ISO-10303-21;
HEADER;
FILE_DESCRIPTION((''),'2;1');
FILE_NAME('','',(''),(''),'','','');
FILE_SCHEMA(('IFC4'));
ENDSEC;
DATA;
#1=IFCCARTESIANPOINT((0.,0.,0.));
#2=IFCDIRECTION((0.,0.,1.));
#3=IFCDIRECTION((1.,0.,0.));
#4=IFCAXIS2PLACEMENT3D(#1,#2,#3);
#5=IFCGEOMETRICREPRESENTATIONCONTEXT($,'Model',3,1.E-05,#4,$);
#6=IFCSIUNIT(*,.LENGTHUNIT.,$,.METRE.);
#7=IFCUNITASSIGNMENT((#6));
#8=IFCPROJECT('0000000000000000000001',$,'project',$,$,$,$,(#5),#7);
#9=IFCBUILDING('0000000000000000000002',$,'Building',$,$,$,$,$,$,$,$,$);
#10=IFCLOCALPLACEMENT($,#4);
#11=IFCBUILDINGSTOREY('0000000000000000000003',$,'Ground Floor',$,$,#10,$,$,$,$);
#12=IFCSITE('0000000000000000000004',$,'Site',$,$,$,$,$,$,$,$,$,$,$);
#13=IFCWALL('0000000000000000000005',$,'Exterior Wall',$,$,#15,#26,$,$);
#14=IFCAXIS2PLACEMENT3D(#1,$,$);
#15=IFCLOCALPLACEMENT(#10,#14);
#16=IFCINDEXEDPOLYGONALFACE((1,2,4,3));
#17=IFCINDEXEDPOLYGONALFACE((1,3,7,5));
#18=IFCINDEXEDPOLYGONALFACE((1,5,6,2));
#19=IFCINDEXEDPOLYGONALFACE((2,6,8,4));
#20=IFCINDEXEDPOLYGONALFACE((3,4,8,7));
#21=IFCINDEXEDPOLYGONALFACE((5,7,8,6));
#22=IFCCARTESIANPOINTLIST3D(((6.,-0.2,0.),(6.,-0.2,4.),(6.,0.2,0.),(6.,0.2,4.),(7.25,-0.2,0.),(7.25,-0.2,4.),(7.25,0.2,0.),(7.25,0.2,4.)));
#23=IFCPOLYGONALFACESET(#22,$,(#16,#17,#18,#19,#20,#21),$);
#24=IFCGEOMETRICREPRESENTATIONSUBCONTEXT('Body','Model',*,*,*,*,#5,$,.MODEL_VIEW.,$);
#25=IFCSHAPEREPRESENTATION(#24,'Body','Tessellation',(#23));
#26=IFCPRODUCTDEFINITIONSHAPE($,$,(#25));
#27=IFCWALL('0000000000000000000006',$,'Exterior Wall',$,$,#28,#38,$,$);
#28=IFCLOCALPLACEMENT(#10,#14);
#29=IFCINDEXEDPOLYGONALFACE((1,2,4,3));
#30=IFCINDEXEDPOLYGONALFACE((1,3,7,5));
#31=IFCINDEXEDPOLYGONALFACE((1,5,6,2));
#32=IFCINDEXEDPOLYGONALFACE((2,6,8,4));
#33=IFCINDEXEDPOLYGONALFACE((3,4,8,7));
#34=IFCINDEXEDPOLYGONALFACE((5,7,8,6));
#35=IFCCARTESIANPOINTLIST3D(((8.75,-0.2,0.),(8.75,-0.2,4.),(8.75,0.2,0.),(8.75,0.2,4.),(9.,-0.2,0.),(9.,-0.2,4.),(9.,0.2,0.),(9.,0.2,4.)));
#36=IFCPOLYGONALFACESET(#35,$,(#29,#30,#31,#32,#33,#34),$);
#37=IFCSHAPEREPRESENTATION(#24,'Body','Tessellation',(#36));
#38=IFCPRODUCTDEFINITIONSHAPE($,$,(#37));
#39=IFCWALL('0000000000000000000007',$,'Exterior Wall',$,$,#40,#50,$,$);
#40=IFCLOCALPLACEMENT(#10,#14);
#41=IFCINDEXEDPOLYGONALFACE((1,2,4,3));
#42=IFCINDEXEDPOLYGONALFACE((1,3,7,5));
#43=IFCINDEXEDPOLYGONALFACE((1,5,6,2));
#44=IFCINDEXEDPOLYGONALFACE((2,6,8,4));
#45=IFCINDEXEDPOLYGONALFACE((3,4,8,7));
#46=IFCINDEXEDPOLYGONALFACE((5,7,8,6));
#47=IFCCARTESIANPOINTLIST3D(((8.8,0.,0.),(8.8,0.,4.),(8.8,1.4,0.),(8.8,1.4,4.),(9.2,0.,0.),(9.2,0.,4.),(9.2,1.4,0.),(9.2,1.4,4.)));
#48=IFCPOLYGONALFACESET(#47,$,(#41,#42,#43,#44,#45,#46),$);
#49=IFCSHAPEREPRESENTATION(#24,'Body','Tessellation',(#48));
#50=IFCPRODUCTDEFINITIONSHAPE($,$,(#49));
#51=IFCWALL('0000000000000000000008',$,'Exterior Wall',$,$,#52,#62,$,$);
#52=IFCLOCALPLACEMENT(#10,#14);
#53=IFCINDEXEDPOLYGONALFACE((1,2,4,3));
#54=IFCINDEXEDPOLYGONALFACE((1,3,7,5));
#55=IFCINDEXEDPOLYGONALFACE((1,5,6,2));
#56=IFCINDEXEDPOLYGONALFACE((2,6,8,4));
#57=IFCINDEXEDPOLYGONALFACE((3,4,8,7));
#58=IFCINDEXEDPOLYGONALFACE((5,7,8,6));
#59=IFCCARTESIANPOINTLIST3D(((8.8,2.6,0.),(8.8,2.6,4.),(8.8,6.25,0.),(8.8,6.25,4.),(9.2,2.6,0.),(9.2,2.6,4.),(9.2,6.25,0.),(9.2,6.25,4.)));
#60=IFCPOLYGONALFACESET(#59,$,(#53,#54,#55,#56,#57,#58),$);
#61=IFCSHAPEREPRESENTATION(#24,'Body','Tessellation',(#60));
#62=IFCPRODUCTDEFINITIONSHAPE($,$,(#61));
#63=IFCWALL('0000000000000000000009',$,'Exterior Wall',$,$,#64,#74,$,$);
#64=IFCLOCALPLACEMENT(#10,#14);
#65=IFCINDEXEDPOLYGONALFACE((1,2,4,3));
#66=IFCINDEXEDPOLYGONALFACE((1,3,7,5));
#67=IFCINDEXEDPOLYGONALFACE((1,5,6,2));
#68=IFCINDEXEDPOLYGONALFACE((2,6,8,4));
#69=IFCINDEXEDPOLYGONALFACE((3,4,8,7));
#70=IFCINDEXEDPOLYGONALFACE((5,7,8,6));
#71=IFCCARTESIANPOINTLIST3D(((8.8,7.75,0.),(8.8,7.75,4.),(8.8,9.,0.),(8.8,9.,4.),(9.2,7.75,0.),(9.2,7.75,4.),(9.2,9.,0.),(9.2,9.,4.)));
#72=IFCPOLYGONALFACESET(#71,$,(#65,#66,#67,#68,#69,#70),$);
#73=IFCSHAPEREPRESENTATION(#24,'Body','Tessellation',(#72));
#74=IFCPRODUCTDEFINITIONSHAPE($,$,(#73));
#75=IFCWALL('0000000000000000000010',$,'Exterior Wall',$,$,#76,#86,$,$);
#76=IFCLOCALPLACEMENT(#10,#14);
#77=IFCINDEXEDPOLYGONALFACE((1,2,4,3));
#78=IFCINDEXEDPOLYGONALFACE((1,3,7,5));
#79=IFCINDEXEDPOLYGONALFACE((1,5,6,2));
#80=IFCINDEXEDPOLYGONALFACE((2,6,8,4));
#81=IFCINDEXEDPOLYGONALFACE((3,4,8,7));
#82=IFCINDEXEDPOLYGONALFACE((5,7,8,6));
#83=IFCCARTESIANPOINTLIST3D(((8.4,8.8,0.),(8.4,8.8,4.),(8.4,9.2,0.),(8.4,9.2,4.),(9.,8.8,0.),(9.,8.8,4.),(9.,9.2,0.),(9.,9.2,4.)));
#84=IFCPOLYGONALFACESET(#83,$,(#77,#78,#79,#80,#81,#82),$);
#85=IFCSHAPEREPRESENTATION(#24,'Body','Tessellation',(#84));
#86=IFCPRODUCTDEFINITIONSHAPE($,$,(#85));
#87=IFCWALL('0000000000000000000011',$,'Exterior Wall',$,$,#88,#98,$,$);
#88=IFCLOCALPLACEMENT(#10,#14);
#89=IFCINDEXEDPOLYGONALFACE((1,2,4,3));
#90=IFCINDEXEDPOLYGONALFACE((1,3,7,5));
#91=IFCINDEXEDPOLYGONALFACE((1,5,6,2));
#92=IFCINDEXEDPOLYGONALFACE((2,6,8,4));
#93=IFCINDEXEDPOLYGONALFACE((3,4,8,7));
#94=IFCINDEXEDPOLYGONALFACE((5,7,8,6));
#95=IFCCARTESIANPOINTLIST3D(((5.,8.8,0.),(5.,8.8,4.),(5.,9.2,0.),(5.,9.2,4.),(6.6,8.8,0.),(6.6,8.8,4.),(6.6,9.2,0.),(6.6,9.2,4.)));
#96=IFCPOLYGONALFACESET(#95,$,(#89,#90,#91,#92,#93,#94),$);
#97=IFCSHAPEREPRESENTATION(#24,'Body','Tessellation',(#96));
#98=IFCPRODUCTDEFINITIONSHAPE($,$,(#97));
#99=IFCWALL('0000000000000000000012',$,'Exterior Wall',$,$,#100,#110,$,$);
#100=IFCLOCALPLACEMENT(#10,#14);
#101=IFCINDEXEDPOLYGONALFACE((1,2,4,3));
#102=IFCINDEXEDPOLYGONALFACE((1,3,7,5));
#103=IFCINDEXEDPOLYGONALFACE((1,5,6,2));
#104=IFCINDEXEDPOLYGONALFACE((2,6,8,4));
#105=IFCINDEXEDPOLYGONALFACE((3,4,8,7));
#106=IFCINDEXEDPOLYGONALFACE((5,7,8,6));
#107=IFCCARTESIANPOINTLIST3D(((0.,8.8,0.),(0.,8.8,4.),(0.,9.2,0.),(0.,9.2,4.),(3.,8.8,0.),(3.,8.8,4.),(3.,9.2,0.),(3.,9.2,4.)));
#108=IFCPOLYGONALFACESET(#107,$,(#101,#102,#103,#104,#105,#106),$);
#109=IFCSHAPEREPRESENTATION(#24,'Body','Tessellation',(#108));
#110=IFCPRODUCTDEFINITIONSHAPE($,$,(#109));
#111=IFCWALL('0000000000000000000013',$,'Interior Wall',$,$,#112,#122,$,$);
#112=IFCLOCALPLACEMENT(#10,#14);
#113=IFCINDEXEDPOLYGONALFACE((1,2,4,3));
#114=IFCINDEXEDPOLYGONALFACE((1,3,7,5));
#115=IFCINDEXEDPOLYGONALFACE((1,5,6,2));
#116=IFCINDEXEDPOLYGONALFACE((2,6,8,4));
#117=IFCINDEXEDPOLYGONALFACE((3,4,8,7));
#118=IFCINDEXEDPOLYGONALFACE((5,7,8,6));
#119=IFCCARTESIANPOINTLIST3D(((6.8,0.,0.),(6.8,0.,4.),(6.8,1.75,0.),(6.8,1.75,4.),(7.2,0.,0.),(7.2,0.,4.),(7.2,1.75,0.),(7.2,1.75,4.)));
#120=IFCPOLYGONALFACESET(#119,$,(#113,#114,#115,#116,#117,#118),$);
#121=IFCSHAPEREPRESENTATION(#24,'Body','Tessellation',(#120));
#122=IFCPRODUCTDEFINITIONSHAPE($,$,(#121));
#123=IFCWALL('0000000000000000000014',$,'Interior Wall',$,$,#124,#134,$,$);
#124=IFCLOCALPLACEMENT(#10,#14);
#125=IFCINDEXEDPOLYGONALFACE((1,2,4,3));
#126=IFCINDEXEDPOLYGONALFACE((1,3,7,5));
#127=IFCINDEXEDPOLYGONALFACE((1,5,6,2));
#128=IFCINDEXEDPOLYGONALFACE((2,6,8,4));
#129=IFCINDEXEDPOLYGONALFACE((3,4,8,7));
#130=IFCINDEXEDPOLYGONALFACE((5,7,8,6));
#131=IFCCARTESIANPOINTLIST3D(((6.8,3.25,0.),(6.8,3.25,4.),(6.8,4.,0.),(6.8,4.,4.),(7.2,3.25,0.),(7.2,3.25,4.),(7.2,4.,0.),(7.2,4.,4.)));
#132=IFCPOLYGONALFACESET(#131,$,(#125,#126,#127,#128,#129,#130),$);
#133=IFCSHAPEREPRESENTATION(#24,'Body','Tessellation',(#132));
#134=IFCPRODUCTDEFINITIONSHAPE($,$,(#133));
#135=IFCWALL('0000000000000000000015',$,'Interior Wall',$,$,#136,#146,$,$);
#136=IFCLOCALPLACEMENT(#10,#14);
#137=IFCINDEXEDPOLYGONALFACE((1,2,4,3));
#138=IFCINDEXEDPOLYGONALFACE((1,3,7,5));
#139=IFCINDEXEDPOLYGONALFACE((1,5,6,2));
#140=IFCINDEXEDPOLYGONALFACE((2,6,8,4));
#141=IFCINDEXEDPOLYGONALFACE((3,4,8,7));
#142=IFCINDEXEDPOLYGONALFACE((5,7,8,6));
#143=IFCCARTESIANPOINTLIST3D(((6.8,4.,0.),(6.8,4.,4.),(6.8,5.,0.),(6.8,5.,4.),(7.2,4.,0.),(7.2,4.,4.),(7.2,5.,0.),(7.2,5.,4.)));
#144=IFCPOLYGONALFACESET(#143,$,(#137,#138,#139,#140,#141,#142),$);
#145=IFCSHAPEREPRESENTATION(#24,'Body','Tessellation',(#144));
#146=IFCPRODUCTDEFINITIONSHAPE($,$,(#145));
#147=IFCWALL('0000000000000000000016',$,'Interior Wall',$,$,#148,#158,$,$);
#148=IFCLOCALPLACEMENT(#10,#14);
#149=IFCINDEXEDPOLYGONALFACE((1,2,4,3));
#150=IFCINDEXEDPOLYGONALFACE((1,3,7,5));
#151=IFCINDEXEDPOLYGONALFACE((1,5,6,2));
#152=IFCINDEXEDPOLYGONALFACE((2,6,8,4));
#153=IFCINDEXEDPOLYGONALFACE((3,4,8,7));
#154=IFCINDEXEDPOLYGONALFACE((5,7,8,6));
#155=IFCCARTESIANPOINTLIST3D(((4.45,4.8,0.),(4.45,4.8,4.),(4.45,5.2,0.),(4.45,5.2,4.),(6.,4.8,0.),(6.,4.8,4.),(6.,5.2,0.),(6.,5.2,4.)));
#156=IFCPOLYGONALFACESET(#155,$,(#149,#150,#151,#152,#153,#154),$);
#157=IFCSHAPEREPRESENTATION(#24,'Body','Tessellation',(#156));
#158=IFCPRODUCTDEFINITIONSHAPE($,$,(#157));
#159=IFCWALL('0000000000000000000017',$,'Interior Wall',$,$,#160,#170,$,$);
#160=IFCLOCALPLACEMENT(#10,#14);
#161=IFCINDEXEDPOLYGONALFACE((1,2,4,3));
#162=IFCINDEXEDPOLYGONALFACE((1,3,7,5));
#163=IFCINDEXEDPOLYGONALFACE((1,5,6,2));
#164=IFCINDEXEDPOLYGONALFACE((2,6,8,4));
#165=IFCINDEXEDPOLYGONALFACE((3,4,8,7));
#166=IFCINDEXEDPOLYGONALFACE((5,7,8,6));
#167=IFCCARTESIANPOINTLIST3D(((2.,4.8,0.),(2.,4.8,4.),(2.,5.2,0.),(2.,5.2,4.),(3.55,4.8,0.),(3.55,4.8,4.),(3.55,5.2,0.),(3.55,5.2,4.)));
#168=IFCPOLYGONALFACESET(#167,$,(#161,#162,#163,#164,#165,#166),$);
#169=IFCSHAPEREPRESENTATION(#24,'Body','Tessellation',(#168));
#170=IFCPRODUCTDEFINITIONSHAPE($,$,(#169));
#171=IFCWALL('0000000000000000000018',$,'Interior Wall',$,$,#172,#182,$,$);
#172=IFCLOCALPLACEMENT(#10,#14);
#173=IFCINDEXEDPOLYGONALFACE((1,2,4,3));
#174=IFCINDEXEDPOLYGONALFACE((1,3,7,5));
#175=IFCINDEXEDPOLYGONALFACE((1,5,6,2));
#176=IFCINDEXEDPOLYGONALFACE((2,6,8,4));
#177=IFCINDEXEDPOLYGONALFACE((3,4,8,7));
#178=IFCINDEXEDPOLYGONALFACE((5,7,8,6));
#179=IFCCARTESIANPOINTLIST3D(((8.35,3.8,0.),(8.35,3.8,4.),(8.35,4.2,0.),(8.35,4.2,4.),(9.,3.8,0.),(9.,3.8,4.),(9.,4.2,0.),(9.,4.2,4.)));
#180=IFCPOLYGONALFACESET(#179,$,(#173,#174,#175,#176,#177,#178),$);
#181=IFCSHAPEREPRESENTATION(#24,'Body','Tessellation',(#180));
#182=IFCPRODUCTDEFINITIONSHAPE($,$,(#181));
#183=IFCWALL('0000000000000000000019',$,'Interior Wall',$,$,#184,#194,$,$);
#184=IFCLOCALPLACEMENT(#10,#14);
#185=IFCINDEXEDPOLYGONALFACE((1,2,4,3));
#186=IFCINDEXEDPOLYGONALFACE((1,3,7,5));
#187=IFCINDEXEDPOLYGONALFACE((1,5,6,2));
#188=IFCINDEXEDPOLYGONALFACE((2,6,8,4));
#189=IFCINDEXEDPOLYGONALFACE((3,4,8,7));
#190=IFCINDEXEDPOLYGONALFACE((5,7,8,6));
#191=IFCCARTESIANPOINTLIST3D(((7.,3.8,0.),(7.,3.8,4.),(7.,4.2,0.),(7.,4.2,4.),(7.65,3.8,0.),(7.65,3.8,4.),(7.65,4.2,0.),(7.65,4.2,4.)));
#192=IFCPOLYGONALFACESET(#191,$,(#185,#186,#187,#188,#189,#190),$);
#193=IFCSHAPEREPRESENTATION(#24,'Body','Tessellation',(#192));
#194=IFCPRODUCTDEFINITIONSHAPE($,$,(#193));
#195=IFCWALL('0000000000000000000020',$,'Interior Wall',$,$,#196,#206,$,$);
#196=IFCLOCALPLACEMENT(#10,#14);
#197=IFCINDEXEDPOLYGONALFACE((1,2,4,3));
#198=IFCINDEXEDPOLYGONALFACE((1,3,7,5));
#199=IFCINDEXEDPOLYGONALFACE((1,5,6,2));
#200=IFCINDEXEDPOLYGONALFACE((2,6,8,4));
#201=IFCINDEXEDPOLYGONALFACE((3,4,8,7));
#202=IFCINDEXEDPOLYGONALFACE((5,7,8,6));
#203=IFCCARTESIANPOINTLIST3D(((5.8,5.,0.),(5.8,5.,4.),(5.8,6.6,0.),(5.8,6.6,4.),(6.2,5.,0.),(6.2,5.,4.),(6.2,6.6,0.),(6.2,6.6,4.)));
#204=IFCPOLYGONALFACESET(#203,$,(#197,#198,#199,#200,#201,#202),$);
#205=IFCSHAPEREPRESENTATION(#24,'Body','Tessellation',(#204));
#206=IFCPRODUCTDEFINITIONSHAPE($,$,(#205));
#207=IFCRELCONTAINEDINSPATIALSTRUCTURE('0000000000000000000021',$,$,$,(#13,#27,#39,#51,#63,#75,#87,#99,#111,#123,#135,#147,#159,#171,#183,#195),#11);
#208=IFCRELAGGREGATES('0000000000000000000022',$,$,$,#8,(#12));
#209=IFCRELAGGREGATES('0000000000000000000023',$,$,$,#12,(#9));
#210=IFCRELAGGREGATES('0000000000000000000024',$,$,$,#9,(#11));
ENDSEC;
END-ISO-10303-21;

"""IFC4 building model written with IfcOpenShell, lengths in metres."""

from ifc_helpers import new_model, si_unit, frame, origin_with_axes, place, context, subcontext, project, spatial, indexed_curve, outline, extrude, element, save


model = new_model("IFC4")

# Units and contexts
model_context = context("Model", 3, precision=1e-05, world=origin_with_axes())
body_context = subcontext(model_context, "Body", "Model", "MODEL_VIEW")
ifc_project = project(units=[si_unit("LENGTHUNIT", "METRE")], contexts=[model_context])

# Site, building, storey
site = spatial("IfcSite", under=ifc_project, Name="Site")
building = spatial("IfcBuilding", under=site, Name="Building")
storey_placement = place(None, origin_with_axes())
storey = spatial("IfcBuildingStorey", under=building, at=storey_placement, Name="Ground Floor")

# Walls
wall_1_placement = place(storey_placement, frame((6.0, 0.0, 0.0), z_axis=(0.0, 0.0, 1.0), x_axis=(1.0, 0.0, 0.0)))
element("IfcWall", 1, at=wall_1_placement, inside=storey, Name="Exterior Wall", context=body_context, shape_type="SweptSolid", body=[
    extrude(outline(indexed_curve([(0.0, 0.0), (0.0, 0.4), (1.25, 0.4), (1.25, 0.0), (0.0, 0.0)], self_intersect=False)), frame((0.0, -0.2, 0.0), z_axis=(0.0, 0.0, 1.0), x_axis=(1.0, 0.0, 0.0)), (0.0, 0.0, 1.0), 4.0),
])
wall_2_placement = place(storey_placement, frame((8.75, 0.0, 0.0), z_axis=(0.0, 0.0, 1.0), x_axis=(1.0, 0.0, 0.0)))
element("IfcWall", 2, at=wall_2_placement, inside=storey, Name="Exterior Wall", context=body_context, shape_type="SweptSolid", body=[
    extrude(outline(indexed_curve([(0.0, 0.0), (0.0, 0.4), (0.25, 0.4), (0.25, 0.0), (0.0, 0.0)], self_intersect=False)), frame((0.0, -0.2, 0.0), z_axis=(0.0, 0.0, 1.0), x_axis=(1.0, 0.0, 0.0)), (0.0, 0.0, 1.0), 4.0),
])
wall_3_placement = place(storey_placement, frame((9.0, 0.0, 0.0), z_axis=(0.0, 0.0, 1.0), x_axis=(0.0, 1.0, 0.0)))
element("IfcWall", 3, at=wall_3_placement, inside=storey, Name="Exterior Wall", context=body_context, shape_type="SweptSolid", body=[
    extrude(outline(indexed_curve([(0.0, 0.0), (0.0, 0.4), (1.4, 0.4), (1.4, 0.0), (0.0, 0.0)], self_intersect=False)), frame((0.0, -0.2, 0.0), z_axis=(0.0, 0.0, 1.0), x_axis=(1.0, 0.0, 0.0)), (0.0, 0.0, 1.0), 4.0),
])
wall_4_placement = place(storey_placement, frame((9.0, 2.6, 0.0), z_axis=(0.0, 0.0, 1.0), x_axis=(0.0, 1.0, 0.0)))
element("IfcWall", 4, at=wall_4_placement, inside=storey, Name="Exterior Wall", context=body_context, shape_type="SweptSolid", body=[
    extrude(outline(indexed_curve([(0.0, 0.0), (0.0, 0.4), (3.65, 0.4), (3.65, 0.0), (0.0, 0.0)], self_intersect=False)), frame((0.0, -0.2, 0.0), z_axis=(0.0, 0.0, 1.0), x_axis=(1.0, 0.0, 0.0)), (0.0, 0.0, 1.0), 4.0),
])
wall_5_placement = place(storey_placement, frame((9.0, 7.75, 0.0), z_axis=(0.0, 0.0, 1.0), x_axis=(0.0, 1.0, 0.0)))
element("IfcWall", 5, at=wall_5_placement, inside=storey, Name="Exterior Wall", context=body_context, shape_type="SweptSolid", body=[
    extrude(outline(indexed_curve([(0.0, 0.0), (0.0, 0.4), (1.25, 0.4), (1.25, 0.0), (0.0, 0.0)], self_intersect=False)), frame((0.0, -0.2, 0.0), z_axis=(0.0, 0.0, 1.0), x_axis=(1.0, 0.0, 0.0)), (0.0, 0.0, 1.0), 4.0),
])
wall_6_placement = place(storey_placement, frame((9.0, 9.0, 0.0), z_axis=(0.0, 0.0, 1.0), x_axis=(-1.0, 0.0, 0.0)))
element("IfcWall", 6, at=wall_6_placement, inside=storey, Name="Exterior Wall", context=body_context, shape_type="SweptSolid", body=[
    extrude(outline(indexed_curve([(0.0, 0.0), (0.0, 0.4), (0.6, 0.4), (0.6, 0.0), (0.0, 0.0)], self_intersect=False)), frame((0.0, -0.2, 0.0), z_axis=(0.0, 0.0, 1.0), x_axis=(1.0, 0.0, 0.0)), (0.0, 0.0, 1.0), 4.0),
])
wall_7_placement = place(storey_placement, frame((6.6, 9.0, 0.0), z_axis=(0.0, 0.0, 1.0), x_axis=(-1.0, 0.0, 0.0)))
element("IfcWall", 7, at=wall_7_placement, inside=storey, Name="Exterior Wall", context=body_context, shape_type="SweptSolid", body=[
    extrude(outline(indexed_curve([(0.0, 0.0), (0.0, 0.4), (1.6, 0.4), (1.6, 0.0), (0.0, 0.0)], self_intersect=False)), frame((0.0, -0.2, 0.0), z_axis=(0.0, 0.0, 1.0), x_axis=(1.0, 0.0, 0.0)), (0.0, 0.0, 1.0), 4.0),
])
wall_8_placement = place(storey_placement, frame((3.0, 9.0, 0.0), z_axis=(0.0, 0.0, 1.0), x_axis=(-1.0, 0.0, 0.0)))
element("IfcWall", 8, at=wall_8_placement, inside=storey, Name="Exterior Wall", context=body_context, shape_type="SweptSolid", body=[
    extrude(outline(indexed_curve([(0.0, 0.0), (0.0, 0.4), (3.0, 0.4), (3.0, 0.0), (0.0, 0.0)], self_intersect=False)), frame((0.0, -0.2, 0.0), z_axis=(0.0, 0.0, 1.0), x_axis=(1.0, 0.0, 0.0)), (0.0, 0.0, 1.0), 4.0),
])
wall_9_placement = place(storey_placement, frame((7.0, 0.0, 0.0), z_axis=(0.0, 0.0, 1.0), x_axis=(0.0, 1.0, 0.0)))
element("IfcWall", 9, at=wall_9_placement, inside=storey, Name="Interior Wall", context=body_context, shape_type="SweptSolid", body=[
    extrude(outline(indexed_curve([(0.0, 0.0), (0.0, 0.4), (1.75, 0.4), (1.75, 0.0), (0.0, 0.0)], self_intersect=False)), frame((0.0, -0.2, 0.0), z_axis=(0.0, 0.0, 1.0), x_axis=(1.0, 0.0, 0.0)), (0.0, 0.0, 1.0), 4.0),
])
wall_10_placement = place(storey_placement, frame((7.0, 3.25, 0.0), z_axis=(0.0, 0.0, 1.0), x_axis=(0.0, 1.0, 0.0)))
element("IfcWall", 10, at=wall_10_placement, inside=storey, Name="Interior Wall", context=body_context, shape_type="SweptSolid", body=[
    extrude(outline(indexed_curve([(0.0, 0.0), (0.0, 0.4), (0.75, 0.4), (0.75, 0.0), (0.0, 0.0)], self_intersect=False)), frame((0.0, -0.2, 0.0), z_axis=(0.0, 0.0, 1.0), x_axis=(1.0, 0.0, 0.0)), (0.0, 0.0, 1.0), 4.0),
])
wall_11_placement = place(storey_placement, frame((7.0, 4.0, 0.0), z_axis=(0.0, 0.0, 1.0), x_axis=(0.0, 1.0, 0.0)))
element("IfcWall", 11, at=wall_11_placement, inside=storey, Name="Interior Wall", context=body_context, shape_type="SweptSolid", body=[
    extrude(outline(indexed_curve([(0.0, 0.0), (0.0, 0.4), (1.0, 0.4), (1.0, 0.0), (0.0, 0.0)], self_intersect=False)), frame((0.0, -0.2, 0.0), z_axis=(0.0, 0.0, 1.0), x_axis=(1.0, 0.0, 0.0)), (0.0, 0.0, 1.0), 4.0),
])
for number, where, z_axis, x_axis, name in (
    (12, (6.0, 5.0, 0.0), (0.0, 0.0, 1.0), (-1.0, 0.0, 0.0), "Interior Wall"),
    (13, (3.55, 5.0, 0.0), (0.0, 0.0, 1.0), (-1.0, 0.0, 0.0), "Interior Wall"),
):
    element("IfcWall", number, at=place(storey_placement, frame(where, z_axis=z_axis, x_axis=x_axis)), inside=storey, Name=name, context=body_context, shape_type="SweptSolid", body=[
        extrude(outline(indexed_curve([(0.0, 0.0), (0.0, 0.4), (1.55, 0.4), (1.55, 0.0), (0.0, 0.0)], self_intersect=False)), frame((0.0, -0.2, 0.0), z_axis=(0.0, 0.0, 1.0), x_axis=(1.0, 0.0, 0.0)), (0.0, 0.0, 1.0), 4.0),
    ])
for number, where, z_axis, x_axis, name in (
    (14, (9.0, 4.0, 0.0), (0.0, 0.0, 1.0), (-1.0, 0.0, 0.0), "Interior Wall"),
    (15, (7.65, 4.0, 0.0), (0.0, 0.0, 1.0), (-1.0, 0.0, 0.0), "Interior Wall"),
):
    element("IfcWall", number, at=place(storey_placement, frame(where, z_axis=z_axis, x_axis=x_axis)), inside=storey, Name=name, context=body_context, shape_type="SweptSolid", body=[
        extrude(outline(indexed_curve([(0.0, 0.0), (0.0, 0.4), (0.65, 0.4), (0.65, 0.0), (0.0, 0.0)], self_intersect=False)), frame((0.0, -0.2, 0.0), z_axis=(0.0, 0.0, 1.0), x_axis=(1.0, 0.0, 0.0)), (0.0, 0.0, 1.0), 4.0),
    ])
for number, where, z_axis, x_axis, name in (
    (16, (6.0, 5.0, 0.0), (0.0, 0.0, 1.0), (0.0, 1.0, 0.0), "Interior Wall"),
):
    element("IfcWall", number, at=place(storey_placement, frame(where, z_axis=z_axis, x_axis=x_axis)), inside=storey, Name=name, context=body_context, shape_type="SweptSolid", body=[
        extrude(outline(indexed_curve([(0.0, 0.0), (0.0, 0.4), (1.6, 0.4), (1.6, 0.0), (0.0, 0.0)], self_intersect=False)), frame((0.0, -0.2, 0.0), z_axis=(0.0, 0.0, 1.0), x_axis=(1.0, 0.0, 0.0)), (0.0, 0.0, 1.0), 4.0),
    ])

save(model, "model.ifc")
